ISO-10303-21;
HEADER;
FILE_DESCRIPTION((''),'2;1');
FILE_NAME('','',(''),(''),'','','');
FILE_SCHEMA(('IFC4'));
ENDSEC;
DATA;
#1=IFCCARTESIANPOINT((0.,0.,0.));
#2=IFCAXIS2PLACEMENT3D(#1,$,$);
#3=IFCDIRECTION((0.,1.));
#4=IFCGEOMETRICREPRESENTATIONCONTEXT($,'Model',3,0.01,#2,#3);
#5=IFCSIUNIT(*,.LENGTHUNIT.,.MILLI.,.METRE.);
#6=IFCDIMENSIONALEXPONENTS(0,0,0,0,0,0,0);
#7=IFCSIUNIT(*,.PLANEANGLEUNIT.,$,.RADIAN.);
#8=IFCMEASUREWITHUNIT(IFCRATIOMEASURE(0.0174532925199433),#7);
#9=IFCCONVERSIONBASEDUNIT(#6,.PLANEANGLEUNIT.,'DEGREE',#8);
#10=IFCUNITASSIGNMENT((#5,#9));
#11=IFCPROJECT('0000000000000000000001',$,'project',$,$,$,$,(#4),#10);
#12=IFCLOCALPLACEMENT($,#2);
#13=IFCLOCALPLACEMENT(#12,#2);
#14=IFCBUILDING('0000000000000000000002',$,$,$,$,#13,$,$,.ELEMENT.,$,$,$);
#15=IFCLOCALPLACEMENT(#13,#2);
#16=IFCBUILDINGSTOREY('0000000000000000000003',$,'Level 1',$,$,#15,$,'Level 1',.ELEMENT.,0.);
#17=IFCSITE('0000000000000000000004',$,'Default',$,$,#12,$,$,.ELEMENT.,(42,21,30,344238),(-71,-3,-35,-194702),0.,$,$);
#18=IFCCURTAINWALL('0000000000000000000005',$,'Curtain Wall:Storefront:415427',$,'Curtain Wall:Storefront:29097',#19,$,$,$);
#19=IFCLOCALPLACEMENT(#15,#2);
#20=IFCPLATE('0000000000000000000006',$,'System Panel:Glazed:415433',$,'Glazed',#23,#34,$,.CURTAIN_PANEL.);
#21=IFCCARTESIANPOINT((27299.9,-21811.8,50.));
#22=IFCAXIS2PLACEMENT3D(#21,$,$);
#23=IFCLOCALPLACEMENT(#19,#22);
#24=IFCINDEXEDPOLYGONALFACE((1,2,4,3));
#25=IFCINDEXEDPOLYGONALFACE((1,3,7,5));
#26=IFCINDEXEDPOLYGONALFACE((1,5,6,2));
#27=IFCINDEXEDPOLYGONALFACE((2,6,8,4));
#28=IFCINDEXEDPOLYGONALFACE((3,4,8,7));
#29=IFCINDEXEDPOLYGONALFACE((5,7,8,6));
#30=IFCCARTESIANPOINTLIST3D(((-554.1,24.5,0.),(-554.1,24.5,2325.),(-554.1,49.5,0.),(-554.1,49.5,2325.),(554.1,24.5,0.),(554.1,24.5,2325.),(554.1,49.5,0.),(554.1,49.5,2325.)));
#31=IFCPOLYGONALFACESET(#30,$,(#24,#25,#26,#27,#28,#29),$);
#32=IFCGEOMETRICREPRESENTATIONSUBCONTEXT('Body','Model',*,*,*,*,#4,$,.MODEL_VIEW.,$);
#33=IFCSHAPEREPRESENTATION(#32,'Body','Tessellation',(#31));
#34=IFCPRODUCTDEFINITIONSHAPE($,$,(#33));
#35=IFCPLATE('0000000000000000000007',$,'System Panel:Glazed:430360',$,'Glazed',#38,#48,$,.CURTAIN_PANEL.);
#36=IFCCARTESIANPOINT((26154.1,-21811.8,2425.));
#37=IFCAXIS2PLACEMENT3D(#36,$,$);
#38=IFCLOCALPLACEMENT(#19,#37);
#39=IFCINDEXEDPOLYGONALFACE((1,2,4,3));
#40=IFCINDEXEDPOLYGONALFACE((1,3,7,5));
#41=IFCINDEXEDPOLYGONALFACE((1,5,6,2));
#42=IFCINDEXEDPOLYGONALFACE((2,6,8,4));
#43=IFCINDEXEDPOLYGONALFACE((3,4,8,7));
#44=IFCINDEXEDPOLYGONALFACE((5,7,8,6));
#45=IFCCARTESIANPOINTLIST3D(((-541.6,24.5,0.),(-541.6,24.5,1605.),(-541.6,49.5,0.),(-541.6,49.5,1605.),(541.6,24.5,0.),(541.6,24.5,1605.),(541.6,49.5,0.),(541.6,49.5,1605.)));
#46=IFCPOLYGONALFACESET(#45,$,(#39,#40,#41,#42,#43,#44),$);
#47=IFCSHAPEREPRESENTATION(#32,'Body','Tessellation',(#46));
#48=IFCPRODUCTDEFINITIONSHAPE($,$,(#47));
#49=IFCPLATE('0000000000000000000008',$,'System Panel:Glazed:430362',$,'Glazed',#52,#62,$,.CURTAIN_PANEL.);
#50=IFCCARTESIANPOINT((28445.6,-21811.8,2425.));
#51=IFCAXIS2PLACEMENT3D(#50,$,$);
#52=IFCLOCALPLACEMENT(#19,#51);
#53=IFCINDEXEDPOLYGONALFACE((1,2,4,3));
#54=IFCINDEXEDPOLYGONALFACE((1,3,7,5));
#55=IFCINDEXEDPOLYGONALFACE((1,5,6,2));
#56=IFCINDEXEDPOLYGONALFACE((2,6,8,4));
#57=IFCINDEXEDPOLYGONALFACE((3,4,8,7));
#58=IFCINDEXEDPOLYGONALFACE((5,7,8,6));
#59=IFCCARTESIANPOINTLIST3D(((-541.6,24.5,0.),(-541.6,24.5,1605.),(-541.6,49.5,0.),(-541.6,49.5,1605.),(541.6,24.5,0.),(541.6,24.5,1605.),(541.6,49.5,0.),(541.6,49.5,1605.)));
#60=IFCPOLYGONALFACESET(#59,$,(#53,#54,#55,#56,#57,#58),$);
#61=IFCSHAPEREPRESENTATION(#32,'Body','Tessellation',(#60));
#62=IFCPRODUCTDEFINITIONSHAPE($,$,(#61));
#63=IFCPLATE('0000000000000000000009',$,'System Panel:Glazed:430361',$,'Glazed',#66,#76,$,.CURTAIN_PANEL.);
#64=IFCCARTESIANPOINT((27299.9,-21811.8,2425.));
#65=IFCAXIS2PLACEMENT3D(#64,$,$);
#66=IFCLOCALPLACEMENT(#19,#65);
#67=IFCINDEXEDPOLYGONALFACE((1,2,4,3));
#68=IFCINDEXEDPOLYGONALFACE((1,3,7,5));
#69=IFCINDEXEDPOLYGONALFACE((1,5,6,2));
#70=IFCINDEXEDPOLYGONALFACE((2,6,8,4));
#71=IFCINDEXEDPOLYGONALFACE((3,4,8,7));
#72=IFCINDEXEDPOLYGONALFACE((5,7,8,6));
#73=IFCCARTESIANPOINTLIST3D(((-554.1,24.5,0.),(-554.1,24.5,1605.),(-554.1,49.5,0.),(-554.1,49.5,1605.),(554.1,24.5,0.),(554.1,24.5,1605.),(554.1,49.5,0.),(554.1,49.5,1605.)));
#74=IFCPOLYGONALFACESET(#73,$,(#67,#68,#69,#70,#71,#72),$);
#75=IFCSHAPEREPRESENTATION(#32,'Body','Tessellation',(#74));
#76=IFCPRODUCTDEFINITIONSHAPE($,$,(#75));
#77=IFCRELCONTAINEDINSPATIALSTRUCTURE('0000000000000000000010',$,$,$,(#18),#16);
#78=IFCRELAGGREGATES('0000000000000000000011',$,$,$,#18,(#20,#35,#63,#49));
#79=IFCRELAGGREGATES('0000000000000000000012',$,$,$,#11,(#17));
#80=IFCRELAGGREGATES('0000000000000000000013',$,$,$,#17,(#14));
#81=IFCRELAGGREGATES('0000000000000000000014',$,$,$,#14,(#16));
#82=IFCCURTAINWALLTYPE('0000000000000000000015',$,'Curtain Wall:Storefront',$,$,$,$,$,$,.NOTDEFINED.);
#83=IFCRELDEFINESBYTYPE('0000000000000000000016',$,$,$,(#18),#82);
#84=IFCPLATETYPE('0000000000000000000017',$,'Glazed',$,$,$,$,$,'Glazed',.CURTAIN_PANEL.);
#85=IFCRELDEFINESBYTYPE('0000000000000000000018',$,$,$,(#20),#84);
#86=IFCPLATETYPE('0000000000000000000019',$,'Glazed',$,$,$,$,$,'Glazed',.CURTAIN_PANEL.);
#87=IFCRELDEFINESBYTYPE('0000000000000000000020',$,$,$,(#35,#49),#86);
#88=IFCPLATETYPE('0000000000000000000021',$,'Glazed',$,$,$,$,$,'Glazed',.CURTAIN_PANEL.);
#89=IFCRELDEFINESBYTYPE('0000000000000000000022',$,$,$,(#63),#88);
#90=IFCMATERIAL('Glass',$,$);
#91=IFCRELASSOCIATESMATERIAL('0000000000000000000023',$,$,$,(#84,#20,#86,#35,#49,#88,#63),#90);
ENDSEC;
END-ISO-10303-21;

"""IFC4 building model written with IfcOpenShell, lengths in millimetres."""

from ifc_helpers import new_model, entity, si_unit, converted_unit, direction, frame, origin, origin_2d_with_axis, place, context, subcontext, project, spatial, rectangle, extrude, source, transform, mapped, material, type_object, type_shapes, element, aggregate, save


model = new_model("IFC4")

# Units and contexts
model_context = context("Model", 3, precision=0.01, world=origin(), true_north=direction((0.0, 1.0)))
body_context = subcontext(model_context, "Body", "Model", "MODEL_VIEW")
ifc_project = project(units=[si_unit("LENGTHUNIT", "METRE", prefix="MILLI"), converted_unit("PLANEANGLEUNIT", "DEGREE", entity("IfcRatioMeasure", 0.0174532925199433), si_unit("PLANEANGLEUNIT", "RADIAN"), dimensions=[0, 0, 0, 0, 0, 0, 0])], contexts=[model_context])

# Site, building, storey
site_placement = place(None, origin())
site = spatial("IfcSite", under=ifc_project, at=site_placement, Name="Default", CompositionType="ELEMENT", RefLatitude=(42, 21, 30, 344238), RefLongitude=(-71, -3, -35, -194702), RefElevation=0.0)
building_placement = place(site_placement, origin())
building = spatial("IfcBuilding", under=site, at=building_placement, CompositionType="ELEMENT")
storey_placement = place(building_placement, origin())
storey = spatial("IfcBuildingStorey", under=building, at=storey_placement, Name="Level 1", LongName="Level 1", CompositionType="ELEMENT", Elevation=0.0)

# Curtain wall, plates
curtain_wall_type = type_object("IfcCurtainWallType", Name="Curtain Wall:Storefront", PredefinedType="NOTDEFINED")
ifc_material_1 = material(Name="Glass")
curtain_wall_1_placement = place(storey_placement, origin())
curtain_wall_1 = element("IfcCurtainWall", 1, at=curtain_wall_1_placement, inside=storey, type_object=curtain_wall_type, Name="Curtain Wall:Storefront:415427", ObjectType="Curtain Wall:Storefront:29097")
plate_type_1 = type_object("IfcPlateType", Name="Glazed", ElementType="Glazed", PredefinedType="CURTAIN_PANEL", material=ifc_material_1)
shared_shape_1 = source(origin(), body_context, "Body", "SweptSolid", [
    extrude(rectangle(XDim=25.0, YDim=1108.3, at=origin_2d_with_axis()), frame((0.0, 37.0, 0.0), z_axis=(0.0, 0.0, 1.0), x_axis=(0.0, 1.0, 0.0)), (0.0, 0.0, 1.0), 2325.0),
])
type_shapes(plate_type_1, [shared_shape_1])
plate_1_placement = place(curtain_wall_1_placement, frame((27299.9, -21811.8, 50.0)))
plate_1 = element("IfcPlate", 2, at=plate_1_placement, type_object=plate_type_1, material=ifc_material_1, Name="System Panel:Glazed:415433", ObjectType="Glazed", PredefinedType="CURTAIN_PANEL", context=body_context, shape_type="MappedRepresentation", body=[
    mapped(shared_shape_1, transform((0.0, 0.0, 0.0), scale=1.0)),
])
plate_type_2 = type_object("IfcPlateType", Name="Glazed", ElementType="Glazed", PredefinedType="CURTAIN_PANEL", material=ifc_material_1)
shared_shape_2 = source(origin(), body_context, "Body", "SweptSolid", [
    extrude(rectangle(XDim=25.0, YDim=1083.3, at=origin_2d_with_axis()), frame((0.0, 37.0, 0.0), z_axis=(0.0, 0.0, 1.0), x_axis=(0.0, 1.0, 0.0)), (0.0, 0.0, 1.0), 1605.0),
])
type_shapes(plate_type_2, [shared_shape_2])
plate_2_placement = place(curtain_wall_1_placement, frame((26154.1, -21811.8, 2425.0)))
plate_2 = element("IfcPlate", 3, at=plate_2_placement, type_object=plate_type_2, material=ifc_material_1, Name="System Panel:Glazed:430360", ObjectType="Glazed", PredefinedType="CURTAIN_PANEL", context=body_context, shape_type="MappedRepresentation", body=[
    mapped(shared_shape_2, transform((0.0, 0.0, 0.0), scale=1.0)),
])
plate_3_placement = place(curtain_wall_1_placement, frame((28445.6, -21811.8, 2425.0)))
plate_3 = element("IfcPlate", 4, at=plate_3_placement, type_object=plate_type_2, material=ifc_material_1, Name="System Panel:Glazed:430362", ObjectType="Glazed", PredefinedType="CURTAIN_PANEL", context=body_context, shape_type="MappedRepresentation", body=[
    mapped(shared_shape_2, transform((0.0, 0.0, 0.0), scale=1.0)),
])
plate_type_3 = type_object("IfcPlateType", Name="Glazed", ElementType="Glazed", PredefinedType="CURTAIN_PANEL", material=ifc_material_1)
shared_shape_3 = source(origin(), body_context, "Body", "SweptSolid", [
    extrude(rectangle(XDim=25.0, YDim=1108.3, at=origin_2d_with_axis()), frame((0.0, 37.0, 0.0), z_axis=(0.0, 0.0, 1.0), x_axis=(0.0, 1.0, 0.0)), (0.0, 0.0, 1.0), 1605.0),
])
type_shapes(plate_type_3, [shared_shape_3])
plate_4_placement = place(curtain_wall_1_placement, frame((27299.9, -21811.8, 2425.0)))
plate_4 = element("IfcPlate", 5, at=plate_4_placement, type_object=plate_type_3, material=ifc_material_1, Name="System Panel:Glazed:430361", ObjectType="Glazed", PredefinedType="CURTAIN_PANEL", context=body_context, shape_type="MappedRepresentation", body=[
    mapped(shared_shape_3, transform((0.0, 0.0, 0.0), scale=1.0)),
])
aggregate(curtain_wall_1, [plate_1, plate_2, plate_4, plate_3])

save(model, "model.ifc")
